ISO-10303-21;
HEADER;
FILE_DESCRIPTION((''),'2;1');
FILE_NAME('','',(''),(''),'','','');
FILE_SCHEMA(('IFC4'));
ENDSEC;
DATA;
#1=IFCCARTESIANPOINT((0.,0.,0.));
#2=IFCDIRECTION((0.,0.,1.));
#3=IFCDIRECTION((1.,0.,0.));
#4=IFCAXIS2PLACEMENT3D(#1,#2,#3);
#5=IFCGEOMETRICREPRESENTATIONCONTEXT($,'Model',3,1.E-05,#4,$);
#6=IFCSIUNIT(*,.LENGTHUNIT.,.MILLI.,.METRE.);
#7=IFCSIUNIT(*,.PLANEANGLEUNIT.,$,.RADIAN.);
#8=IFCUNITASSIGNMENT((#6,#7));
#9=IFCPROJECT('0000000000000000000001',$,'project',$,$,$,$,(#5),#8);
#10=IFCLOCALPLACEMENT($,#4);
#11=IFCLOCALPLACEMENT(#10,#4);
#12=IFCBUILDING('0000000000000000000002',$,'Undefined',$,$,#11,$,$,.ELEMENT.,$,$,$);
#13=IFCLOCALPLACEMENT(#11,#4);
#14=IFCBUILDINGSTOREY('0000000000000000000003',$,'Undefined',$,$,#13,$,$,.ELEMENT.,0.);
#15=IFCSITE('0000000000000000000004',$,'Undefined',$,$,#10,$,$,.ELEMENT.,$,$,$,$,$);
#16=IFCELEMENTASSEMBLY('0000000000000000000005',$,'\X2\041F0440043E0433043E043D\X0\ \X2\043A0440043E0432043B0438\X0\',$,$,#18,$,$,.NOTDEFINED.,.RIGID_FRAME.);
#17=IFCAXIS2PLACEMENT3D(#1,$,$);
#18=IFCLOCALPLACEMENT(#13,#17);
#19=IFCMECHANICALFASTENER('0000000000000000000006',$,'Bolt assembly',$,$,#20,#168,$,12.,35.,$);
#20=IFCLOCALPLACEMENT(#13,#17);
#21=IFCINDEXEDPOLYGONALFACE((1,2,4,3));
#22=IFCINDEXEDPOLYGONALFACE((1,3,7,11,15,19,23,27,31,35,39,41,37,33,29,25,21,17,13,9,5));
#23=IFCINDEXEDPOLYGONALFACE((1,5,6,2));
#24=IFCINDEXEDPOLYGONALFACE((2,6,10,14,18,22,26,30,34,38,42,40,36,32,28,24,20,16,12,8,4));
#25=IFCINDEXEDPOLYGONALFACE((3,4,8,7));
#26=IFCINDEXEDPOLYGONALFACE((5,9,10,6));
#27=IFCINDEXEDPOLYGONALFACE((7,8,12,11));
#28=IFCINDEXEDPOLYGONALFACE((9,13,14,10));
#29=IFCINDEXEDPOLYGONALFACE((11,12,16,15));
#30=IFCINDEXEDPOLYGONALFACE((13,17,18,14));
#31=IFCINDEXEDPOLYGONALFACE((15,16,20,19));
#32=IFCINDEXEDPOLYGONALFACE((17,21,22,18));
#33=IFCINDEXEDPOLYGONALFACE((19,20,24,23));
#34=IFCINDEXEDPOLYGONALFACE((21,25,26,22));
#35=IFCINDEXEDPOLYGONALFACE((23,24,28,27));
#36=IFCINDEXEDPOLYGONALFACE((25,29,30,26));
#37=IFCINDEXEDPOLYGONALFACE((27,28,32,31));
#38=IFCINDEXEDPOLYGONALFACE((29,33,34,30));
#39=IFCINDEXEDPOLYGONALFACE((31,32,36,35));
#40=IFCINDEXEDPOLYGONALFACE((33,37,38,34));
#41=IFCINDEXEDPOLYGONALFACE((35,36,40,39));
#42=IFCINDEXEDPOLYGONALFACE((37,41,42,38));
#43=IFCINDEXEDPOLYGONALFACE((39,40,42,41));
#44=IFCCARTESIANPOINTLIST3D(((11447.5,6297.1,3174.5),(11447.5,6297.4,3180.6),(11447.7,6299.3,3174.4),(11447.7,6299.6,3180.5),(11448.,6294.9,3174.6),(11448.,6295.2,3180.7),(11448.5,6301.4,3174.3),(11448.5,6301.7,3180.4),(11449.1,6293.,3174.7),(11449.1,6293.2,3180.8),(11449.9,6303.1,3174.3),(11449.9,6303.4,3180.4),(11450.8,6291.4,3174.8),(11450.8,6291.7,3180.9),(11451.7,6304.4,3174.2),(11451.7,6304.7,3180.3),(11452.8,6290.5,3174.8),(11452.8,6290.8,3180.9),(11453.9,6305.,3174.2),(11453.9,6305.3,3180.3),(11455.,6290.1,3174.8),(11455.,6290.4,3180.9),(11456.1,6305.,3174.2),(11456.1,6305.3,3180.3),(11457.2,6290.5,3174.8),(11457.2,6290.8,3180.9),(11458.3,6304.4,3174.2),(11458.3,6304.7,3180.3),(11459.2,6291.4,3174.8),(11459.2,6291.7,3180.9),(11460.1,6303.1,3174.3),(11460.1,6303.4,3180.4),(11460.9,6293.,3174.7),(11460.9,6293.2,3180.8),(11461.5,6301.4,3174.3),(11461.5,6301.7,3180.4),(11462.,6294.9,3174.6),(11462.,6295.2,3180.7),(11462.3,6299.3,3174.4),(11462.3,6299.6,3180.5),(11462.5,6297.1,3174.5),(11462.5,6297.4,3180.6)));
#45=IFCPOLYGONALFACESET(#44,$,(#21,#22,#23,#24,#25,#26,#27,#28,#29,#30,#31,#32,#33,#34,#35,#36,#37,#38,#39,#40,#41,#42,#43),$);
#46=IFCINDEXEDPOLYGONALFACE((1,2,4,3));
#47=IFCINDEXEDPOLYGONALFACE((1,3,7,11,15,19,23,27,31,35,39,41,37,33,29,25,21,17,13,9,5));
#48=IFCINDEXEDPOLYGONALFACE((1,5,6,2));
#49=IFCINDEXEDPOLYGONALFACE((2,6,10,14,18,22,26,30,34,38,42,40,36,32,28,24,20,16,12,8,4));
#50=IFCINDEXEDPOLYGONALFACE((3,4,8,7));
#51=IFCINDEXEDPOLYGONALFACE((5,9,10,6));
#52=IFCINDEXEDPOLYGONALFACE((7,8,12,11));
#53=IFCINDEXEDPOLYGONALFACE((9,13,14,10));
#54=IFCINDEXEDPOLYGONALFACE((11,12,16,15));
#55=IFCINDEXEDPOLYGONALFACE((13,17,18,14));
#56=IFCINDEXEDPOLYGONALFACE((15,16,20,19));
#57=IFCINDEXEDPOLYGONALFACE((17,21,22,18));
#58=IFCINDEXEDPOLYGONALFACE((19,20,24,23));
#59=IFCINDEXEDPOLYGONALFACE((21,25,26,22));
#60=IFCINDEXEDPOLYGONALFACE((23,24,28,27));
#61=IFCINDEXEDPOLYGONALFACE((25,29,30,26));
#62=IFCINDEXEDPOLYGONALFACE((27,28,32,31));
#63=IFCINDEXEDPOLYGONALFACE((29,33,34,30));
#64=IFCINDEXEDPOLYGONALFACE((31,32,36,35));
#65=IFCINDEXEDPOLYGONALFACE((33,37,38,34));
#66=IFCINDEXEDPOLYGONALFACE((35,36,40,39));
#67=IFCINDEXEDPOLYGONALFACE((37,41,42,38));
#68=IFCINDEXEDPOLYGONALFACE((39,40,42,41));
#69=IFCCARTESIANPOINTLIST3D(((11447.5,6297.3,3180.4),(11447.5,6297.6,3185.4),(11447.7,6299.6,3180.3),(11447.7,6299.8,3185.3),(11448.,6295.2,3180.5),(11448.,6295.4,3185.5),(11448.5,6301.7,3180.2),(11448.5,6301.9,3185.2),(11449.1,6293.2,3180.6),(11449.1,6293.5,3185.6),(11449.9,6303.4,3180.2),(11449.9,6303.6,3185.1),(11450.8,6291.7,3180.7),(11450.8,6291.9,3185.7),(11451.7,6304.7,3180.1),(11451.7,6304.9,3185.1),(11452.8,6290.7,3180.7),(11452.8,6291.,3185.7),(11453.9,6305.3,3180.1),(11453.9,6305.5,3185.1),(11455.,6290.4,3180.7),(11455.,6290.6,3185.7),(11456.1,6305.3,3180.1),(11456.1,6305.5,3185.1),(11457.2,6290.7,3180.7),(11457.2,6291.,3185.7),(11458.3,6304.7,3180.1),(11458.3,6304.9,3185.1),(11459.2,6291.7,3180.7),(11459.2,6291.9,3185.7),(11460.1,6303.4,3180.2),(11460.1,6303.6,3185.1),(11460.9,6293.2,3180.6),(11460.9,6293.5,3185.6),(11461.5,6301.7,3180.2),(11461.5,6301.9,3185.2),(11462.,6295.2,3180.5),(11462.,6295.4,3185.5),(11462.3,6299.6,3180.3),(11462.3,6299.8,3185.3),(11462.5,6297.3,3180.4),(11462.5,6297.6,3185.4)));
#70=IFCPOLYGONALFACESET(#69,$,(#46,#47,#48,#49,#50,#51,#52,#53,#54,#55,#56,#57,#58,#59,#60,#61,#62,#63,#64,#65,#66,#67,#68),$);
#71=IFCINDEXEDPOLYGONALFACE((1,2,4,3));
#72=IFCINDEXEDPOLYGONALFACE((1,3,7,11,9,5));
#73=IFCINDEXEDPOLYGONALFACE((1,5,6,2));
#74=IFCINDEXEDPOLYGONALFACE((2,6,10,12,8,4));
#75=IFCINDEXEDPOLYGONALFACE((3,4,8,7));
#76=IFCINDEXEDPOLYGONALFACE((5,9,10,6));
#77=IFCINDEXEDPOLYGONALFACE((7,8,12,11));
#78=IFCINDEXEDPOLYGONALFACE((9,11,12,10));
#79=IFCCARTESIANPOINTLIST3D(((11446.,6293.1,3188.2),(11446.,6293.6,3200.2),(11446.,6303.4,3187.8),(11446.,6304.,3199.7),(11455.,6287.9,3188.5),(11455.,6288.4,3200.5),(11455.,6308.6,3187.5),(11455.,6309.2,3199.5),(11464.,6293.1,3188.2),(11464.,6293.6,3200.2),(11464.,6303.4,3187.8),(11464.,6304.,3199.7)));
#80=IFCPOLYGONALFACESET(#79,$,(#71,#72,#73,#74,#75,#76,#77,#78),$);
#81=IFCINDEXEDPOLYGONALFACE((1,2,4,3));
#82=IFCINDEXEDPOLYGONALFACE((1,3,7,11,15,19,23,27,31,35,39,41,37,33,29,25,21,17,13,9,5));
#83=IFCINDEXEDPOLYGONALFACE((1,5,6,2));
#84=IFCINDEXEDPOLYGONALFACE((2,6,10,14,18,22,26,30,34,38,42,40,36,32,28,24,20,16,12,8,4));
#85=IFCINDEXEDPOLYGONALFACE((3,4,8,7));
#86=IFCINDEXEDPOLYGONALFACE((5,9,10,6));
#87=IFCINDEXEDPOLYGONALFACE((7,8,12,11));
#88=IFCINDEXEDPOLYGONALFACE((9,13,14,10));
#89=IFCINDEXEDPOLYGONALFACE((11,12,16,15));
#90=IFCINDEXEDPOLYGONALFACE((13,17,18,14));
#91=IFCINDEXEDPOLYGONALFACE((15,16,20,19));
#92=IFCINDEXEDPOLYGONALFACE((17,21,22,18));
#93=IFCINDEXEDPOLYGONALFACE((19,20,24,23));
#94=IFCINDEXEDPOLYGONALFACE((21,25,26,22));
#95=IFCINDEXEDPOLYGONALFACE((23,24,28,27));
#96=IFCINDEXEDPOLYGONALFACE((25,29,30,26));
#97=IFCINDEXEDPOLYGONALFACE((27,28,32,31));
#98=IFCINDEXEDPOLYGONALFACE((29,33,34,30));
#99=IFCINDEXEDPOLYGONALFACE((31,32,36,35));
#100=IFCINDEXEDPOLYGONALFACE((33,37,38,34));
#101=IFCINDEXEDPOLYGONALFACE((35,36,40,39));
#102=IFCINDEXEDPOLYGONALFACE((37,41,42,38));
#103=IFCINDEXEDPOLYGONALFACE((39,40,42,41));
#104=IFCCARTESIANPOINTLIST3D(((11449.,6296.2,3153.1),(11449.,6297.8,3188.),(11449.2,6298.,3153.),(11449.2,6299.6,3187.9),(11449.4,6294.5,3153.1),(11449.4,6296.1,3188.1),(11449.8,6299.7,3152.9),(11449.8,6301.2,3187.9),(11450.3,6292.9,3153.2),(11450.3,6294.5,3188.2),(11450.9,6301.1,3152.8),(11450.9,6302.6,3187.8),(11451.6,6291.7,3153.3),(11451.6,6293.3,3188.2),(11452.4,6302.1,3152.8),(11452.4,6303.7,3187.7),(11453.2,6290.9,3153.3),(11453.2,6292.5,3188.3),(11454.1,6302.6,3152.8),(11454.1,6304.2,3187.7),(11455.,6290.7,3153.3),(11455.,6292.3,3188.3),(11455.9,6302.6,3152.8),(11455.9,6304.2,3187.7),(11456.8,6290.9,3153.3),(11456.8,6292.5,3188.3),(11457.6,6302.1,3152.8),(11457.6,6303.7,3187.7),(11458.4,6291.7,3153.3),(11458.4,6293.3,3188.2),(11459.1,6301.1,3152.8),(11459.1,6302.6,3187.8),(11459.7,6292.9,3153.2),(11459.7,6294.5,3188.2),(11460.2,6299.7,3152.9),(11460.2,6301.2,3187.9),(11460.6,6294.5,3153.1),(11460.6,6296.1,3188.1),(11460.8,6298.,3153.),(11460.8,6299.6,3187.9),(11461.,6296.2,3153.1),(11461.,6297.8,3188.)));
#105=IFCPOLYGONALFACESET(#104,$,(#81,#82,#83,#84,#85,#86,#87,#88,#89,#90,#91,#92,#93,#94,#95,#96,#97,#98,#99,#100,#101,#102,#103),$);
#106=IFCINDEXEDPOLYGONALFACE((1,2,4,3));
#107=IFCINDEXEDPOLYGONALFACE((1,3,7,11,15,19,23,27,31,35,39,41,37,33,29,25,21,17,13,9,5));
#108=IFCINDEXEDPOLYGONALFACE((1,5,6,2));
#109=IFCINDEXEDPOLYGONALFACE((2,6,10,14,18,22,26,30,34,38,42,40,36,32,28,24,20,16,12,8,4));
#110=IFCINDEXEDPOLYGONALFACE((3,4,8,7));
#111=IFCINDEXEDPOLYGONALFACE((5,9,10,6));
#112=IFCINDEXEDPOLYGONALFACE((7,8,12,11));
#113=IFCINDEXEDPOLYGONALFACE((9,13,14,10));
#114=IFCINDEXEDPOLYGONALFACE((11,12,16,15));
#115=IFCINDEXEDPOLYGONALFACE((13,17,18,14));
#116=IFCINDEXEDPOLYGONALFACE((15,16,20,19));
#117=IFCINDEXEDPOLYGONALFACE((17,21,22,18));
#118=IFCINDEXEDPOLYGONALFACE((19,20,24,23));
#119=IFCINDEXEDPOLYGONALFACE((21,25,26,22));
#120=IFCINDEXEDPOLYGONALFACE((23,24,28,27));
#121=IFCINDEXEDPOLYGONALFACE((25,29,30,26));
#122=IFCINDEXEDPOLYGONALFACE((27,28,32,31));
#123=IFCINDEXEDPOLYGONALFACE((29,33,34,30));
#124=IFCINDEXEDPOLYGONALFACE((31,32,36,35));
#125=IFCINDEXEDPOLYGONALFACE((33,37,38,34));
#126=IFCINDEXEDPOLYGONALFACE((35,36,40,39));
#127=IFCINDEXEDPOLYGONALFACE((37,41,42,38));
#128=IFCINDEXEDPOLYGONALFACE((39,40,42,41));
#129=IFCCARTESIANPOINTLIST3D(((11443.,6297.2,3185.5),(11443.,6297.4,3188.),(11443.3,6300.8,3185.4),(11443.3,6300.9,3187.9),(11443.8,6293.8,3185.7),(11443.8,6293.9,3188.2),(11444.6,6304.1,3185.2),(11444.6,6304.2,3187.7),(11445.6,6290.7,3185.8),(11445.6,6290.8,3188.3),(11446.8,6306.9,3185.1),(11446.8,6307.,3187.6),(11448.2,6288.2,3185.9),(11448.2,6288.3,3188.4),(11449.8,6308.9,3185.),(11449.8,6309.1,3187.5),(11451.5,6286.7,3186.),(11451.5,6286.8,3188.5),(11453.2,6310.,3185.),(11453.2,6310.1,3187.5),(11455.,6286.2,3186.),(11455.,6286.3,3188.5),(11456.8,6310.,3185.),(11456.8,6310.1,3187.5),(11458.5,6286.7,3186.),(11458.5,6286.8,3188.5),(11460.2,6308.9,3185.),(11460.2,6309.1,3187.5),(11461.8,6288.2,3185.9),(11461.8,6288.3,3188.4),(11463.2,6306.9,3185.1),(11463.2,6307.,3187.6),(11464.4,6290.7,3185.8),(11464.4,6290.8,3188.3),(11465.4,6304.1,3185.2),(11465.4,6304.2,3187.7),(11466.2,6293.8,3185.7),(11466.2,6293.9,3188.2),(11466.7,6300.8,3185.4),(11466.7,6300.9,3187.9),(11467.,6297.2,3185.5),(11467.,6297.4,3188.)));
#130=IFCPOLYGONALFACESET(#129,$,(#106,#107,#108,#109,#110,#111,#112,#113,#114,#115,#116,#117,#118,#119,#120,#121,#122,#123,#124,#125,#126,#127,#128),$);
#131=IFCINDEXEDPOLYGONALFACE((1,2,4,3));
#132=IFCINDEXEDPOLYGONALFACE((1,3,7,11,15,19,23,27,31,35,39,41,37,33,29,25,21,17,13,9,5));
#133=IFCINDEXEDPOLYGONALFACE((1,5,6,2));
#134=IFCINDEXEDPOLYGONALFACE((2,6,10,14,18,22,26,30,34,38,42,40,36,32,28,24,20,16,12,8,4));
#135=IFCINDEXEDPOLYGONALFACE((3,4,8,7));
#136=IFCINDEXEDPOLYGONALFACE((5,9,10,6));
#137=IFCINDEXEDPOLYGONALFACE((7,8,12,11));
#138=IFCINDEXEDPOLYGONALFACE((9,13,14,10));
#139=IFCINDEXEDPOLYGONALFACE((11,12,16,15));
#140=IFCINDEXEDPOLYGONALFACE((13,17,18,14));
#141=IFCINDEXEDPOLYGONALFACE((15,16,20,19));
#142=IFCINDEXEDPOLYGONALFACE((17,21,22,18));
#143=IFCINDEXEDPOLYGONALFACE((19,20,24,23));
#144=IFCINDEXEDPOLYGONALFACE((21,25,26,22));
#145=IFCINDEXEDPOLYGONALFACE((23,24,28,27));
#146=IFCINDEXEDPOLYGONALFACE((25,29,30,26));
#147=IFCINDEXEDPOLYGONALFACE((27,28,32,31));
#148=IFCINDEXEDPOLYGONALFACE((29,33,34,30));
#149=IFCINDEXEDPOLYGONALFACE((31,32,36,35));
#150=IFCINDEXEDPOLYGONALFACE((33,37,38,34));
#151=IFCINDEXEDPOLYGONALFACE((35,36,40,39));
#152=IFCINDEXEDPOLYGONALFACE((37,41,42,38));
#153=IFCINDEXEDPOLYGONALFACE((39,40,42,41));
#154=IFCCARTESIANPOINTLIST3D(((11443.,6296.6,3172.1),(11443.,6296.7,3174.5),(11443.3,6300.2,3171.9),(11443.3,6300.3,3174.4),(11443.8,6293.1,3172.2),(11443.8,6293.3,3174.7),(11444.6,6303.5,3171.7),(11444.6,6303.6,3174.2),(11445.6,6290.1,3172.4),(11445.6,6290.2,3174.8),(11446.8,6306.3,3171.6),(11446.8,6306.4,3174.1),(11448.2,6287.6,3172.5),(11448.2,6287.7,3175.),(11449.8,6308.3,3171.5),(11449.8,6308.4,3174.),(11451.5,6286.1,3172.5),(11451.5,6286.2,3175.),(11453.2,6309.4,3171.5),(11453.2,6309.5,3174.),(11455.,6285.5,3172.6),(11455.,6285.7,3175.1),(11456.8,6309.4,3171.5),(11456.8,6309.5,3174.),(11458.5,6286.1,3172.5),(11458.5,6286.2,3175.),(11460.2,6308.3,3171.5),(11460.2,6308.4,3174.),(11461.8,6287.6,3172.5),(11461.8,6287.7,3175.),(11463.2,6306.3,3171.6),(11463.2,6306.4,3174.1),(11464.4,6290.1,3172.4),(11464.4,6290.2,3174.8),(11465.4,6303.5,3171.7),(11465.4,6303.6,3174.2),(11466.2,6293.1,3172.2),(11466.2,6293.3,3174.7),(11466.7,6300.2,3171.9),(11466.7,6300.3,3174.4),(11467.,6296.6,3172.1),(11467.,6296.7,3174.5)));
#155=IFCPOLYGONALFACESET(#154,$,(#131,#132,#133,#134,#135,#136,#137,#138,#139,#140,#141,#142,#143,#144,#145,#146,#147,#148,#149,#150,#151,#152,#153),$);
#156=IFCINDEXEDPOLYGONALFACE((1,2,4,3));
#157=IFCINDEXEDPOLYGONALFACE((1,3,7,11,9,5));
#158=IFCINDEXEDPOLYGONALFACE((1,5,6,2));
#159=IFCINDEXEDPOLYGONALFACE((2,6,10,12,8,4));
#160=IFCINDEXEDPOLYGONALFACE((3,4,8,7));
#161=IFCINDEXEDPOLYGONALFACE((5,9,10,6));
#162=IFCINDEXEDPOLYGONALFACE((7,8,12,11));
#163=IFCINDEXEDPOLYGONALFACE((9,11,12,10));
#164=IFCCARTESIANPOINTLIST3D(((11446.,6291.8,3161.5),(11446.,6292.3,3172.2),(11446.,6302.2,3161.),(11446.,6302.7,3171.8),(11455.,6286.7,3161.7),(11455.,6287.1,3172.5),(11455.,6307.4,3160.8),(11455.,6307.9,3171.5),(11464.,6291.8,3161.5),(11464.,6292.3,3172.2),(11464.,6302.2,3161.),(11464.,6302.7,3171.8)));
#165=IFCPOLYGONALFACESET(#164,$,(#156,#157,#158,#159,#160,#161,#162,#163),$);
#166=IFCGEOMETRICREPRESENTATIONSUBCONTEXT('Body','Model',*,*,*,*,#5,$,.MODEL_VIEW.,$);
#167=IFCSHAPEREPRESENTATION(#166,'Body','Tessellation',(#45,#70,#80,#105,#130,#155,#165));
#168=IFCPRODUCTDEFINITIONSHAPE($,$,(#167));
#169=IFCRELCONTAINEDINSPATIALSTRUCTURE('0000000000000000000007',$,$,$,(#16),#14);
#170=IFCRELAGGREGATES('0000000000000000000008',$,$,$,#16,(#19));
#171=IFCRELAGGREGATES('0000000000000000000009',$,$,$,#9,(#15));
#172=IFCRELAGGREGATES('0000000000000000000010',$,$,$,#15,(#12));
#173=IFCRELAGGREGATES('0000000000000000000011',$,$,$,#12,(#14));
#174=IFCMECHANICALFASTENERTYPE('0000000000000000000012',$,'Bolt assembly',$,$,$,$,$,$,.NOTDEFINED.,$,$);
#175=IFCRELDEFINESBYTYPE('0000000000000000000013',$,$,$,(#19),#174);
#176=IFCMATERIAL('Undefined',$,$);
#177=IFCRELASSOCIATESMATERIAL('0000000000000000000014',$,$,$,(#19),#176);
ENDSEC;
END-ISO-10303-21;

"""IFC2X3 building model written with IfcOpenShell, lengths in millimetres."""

from ifc_helpers import new_model, si_unit, frame, origin_with_axes, origin_2d_with_axis, place, context, subcontext, project, spatial, polyline, circle, outline, extrude, source, transform, mapped, material, type_object, element, aggregate, save


model = new_model("IFC2X3")

# Units and contexts
model_context = context("Model", 3, precision=1e-05, world=origin_with_axes())
body_context = subcontext(model_context, "Body", "Model", "MODEL_VIEW")
ifc_project = project(units=[si_unit("LENGTHUNIT", "METRE", prefix="MILLI"), si_unit("PLANEANGLEUNIT", "RADIAN")], contexts=[model_context])

# Site, building, storey
site_placement = place(None, origin_with_axes())
site = spatial("IfcSite", under=ifc_project, at=site_placement, Name="Undefined", CompositionType="ELEMENT")
building_placement = place(site_placement, origin_with_axes())
building = spatial("IfcBuilding", under=site, at=building_placement, Name="Undefined", CompositionType="ELEMENT")
storey_placement = place(building_placement, origin_with_axes())
storey = spatial("IfcBuildingStorey", under=building, at=storey_placement, Name="Undefined", CompositionType="ELEMENT", Elevation=0.0)

# Element assembly
assembly_1_placement = place(storey_placement, origin_with_axes())
assembly_1 = element("IfcElementAssembly", 1, at=assembly_1_placement, inside=storey, Name="Прогон кровли", AssemblyPlace="NOTDEFINED", PredefinedType="RIGID_FRAME")

# Mechanical fastener
ifc_material_1 = material(Name="Undefined")
mechanical_fastener_type = type_object("IfcMechanicalFastenerType", Name="Bolt assembly")
shared_shape_1 = source(origin_with_axes(), body_context, "Body", "SweptSolid", [
    extrude(circle(Radius=7.5, at=origin_2d_with_axis()), frame((0.0, -0.1, 0.0), z_axis=(0.0, 1.0, 0.0), x_axis=(1.0, 0.0, 0.0)), (0.0, 0.0, 1.0), 6.1),
    extrude(circle(Radius=7.5, at=origin_2d_with_axis()), frame((0.0, -4.9, 0.0), z_axis=(0.0, 1.0, 0.0), x_axis=(1.0, 0.0, 0.0)), (0.0, 0.0, 1.0), 5.0),
    extrude(outline(polyline([(10.4, 0.0), (5.2, 9.0), (-5.2, 9.0), (-10.4, 0.0), (-5.2, -9.0), (5.2, -9.0), (10.4, 0.0)])), frame((0.0, -19.5, 0.0), z_axis=(0.0, 1.0, 0.0), x_axis=(1.0, 0.0, 0.0)), (0.0, 0.0, 1.0), 12.0),
    extrude(circle(Radius=6.0, at=origin_2d_with_axis()), frame((0.0, -7.5, 0.0), z_axis=(0.0, 1.0, 0.0), x_axis=(1.0, 0.0, 0.0)), (0.0, 0.0, 1.0), 35.0),
    extrude(circle(Radius=12.0, at=origin_2d_with_axis()), frame((0.0, -7.5, 0.0), z_axis=(0.0, 1.0, 0.0), x_axis=(1.0, 0.0, 0.0)), (0.0, 0.0, 1.0), 2.5),
    extrude(circle(Radius=12.0, at=origin_2d_with_axis()), frame((0.0, 6.0, 0.0), z_axis=(0.0, 1.0, 0.0), x_axis=(1.0, 0.0, 0.0)), (0.0, 0.0, 1.0), 2.5),
    extrude(outline(polyline([(10.4, 0.0), (5.2, 9.0), (-5.2, 9.0), (-10.4, 0.0), (-5.2, -9.0), (5.2, -9.0), (10.4, 0.0)])), frame((0.0, 8.5, 0.0), z_axis=(0.0, 1.0, 0.0), x_axis=(1.0, 0.0, 0.0)), (0.0, 0.0, 1.0), 10.8),
])
mechanical_fastener_1_placement = place(assembly_1_placement, frame((11455.0, 6297.9, 3180.5), z_axis=(1.0, 0.0, 0.0), x_axis=(0.0, -0.998969, 0.045408)))
mechanical_fastener_1 = element("IfcMechanicalFastener", 2, at=mechanical_fastener_1_placement, type_object=mechanical_fastener_type, material=ifc_material_1, Name="Bolt assembly", NominalDiameter=12.0, NominalLength=35.0, context=body_context, shape_type="MappedRepresentation", body=[
    mapped(shared_shape_1, transform((0.0, 0.0, 0.0))),
])
aggregate(assembly_1, [mechanical_fastener_1])

save(model, "model.ifc")
